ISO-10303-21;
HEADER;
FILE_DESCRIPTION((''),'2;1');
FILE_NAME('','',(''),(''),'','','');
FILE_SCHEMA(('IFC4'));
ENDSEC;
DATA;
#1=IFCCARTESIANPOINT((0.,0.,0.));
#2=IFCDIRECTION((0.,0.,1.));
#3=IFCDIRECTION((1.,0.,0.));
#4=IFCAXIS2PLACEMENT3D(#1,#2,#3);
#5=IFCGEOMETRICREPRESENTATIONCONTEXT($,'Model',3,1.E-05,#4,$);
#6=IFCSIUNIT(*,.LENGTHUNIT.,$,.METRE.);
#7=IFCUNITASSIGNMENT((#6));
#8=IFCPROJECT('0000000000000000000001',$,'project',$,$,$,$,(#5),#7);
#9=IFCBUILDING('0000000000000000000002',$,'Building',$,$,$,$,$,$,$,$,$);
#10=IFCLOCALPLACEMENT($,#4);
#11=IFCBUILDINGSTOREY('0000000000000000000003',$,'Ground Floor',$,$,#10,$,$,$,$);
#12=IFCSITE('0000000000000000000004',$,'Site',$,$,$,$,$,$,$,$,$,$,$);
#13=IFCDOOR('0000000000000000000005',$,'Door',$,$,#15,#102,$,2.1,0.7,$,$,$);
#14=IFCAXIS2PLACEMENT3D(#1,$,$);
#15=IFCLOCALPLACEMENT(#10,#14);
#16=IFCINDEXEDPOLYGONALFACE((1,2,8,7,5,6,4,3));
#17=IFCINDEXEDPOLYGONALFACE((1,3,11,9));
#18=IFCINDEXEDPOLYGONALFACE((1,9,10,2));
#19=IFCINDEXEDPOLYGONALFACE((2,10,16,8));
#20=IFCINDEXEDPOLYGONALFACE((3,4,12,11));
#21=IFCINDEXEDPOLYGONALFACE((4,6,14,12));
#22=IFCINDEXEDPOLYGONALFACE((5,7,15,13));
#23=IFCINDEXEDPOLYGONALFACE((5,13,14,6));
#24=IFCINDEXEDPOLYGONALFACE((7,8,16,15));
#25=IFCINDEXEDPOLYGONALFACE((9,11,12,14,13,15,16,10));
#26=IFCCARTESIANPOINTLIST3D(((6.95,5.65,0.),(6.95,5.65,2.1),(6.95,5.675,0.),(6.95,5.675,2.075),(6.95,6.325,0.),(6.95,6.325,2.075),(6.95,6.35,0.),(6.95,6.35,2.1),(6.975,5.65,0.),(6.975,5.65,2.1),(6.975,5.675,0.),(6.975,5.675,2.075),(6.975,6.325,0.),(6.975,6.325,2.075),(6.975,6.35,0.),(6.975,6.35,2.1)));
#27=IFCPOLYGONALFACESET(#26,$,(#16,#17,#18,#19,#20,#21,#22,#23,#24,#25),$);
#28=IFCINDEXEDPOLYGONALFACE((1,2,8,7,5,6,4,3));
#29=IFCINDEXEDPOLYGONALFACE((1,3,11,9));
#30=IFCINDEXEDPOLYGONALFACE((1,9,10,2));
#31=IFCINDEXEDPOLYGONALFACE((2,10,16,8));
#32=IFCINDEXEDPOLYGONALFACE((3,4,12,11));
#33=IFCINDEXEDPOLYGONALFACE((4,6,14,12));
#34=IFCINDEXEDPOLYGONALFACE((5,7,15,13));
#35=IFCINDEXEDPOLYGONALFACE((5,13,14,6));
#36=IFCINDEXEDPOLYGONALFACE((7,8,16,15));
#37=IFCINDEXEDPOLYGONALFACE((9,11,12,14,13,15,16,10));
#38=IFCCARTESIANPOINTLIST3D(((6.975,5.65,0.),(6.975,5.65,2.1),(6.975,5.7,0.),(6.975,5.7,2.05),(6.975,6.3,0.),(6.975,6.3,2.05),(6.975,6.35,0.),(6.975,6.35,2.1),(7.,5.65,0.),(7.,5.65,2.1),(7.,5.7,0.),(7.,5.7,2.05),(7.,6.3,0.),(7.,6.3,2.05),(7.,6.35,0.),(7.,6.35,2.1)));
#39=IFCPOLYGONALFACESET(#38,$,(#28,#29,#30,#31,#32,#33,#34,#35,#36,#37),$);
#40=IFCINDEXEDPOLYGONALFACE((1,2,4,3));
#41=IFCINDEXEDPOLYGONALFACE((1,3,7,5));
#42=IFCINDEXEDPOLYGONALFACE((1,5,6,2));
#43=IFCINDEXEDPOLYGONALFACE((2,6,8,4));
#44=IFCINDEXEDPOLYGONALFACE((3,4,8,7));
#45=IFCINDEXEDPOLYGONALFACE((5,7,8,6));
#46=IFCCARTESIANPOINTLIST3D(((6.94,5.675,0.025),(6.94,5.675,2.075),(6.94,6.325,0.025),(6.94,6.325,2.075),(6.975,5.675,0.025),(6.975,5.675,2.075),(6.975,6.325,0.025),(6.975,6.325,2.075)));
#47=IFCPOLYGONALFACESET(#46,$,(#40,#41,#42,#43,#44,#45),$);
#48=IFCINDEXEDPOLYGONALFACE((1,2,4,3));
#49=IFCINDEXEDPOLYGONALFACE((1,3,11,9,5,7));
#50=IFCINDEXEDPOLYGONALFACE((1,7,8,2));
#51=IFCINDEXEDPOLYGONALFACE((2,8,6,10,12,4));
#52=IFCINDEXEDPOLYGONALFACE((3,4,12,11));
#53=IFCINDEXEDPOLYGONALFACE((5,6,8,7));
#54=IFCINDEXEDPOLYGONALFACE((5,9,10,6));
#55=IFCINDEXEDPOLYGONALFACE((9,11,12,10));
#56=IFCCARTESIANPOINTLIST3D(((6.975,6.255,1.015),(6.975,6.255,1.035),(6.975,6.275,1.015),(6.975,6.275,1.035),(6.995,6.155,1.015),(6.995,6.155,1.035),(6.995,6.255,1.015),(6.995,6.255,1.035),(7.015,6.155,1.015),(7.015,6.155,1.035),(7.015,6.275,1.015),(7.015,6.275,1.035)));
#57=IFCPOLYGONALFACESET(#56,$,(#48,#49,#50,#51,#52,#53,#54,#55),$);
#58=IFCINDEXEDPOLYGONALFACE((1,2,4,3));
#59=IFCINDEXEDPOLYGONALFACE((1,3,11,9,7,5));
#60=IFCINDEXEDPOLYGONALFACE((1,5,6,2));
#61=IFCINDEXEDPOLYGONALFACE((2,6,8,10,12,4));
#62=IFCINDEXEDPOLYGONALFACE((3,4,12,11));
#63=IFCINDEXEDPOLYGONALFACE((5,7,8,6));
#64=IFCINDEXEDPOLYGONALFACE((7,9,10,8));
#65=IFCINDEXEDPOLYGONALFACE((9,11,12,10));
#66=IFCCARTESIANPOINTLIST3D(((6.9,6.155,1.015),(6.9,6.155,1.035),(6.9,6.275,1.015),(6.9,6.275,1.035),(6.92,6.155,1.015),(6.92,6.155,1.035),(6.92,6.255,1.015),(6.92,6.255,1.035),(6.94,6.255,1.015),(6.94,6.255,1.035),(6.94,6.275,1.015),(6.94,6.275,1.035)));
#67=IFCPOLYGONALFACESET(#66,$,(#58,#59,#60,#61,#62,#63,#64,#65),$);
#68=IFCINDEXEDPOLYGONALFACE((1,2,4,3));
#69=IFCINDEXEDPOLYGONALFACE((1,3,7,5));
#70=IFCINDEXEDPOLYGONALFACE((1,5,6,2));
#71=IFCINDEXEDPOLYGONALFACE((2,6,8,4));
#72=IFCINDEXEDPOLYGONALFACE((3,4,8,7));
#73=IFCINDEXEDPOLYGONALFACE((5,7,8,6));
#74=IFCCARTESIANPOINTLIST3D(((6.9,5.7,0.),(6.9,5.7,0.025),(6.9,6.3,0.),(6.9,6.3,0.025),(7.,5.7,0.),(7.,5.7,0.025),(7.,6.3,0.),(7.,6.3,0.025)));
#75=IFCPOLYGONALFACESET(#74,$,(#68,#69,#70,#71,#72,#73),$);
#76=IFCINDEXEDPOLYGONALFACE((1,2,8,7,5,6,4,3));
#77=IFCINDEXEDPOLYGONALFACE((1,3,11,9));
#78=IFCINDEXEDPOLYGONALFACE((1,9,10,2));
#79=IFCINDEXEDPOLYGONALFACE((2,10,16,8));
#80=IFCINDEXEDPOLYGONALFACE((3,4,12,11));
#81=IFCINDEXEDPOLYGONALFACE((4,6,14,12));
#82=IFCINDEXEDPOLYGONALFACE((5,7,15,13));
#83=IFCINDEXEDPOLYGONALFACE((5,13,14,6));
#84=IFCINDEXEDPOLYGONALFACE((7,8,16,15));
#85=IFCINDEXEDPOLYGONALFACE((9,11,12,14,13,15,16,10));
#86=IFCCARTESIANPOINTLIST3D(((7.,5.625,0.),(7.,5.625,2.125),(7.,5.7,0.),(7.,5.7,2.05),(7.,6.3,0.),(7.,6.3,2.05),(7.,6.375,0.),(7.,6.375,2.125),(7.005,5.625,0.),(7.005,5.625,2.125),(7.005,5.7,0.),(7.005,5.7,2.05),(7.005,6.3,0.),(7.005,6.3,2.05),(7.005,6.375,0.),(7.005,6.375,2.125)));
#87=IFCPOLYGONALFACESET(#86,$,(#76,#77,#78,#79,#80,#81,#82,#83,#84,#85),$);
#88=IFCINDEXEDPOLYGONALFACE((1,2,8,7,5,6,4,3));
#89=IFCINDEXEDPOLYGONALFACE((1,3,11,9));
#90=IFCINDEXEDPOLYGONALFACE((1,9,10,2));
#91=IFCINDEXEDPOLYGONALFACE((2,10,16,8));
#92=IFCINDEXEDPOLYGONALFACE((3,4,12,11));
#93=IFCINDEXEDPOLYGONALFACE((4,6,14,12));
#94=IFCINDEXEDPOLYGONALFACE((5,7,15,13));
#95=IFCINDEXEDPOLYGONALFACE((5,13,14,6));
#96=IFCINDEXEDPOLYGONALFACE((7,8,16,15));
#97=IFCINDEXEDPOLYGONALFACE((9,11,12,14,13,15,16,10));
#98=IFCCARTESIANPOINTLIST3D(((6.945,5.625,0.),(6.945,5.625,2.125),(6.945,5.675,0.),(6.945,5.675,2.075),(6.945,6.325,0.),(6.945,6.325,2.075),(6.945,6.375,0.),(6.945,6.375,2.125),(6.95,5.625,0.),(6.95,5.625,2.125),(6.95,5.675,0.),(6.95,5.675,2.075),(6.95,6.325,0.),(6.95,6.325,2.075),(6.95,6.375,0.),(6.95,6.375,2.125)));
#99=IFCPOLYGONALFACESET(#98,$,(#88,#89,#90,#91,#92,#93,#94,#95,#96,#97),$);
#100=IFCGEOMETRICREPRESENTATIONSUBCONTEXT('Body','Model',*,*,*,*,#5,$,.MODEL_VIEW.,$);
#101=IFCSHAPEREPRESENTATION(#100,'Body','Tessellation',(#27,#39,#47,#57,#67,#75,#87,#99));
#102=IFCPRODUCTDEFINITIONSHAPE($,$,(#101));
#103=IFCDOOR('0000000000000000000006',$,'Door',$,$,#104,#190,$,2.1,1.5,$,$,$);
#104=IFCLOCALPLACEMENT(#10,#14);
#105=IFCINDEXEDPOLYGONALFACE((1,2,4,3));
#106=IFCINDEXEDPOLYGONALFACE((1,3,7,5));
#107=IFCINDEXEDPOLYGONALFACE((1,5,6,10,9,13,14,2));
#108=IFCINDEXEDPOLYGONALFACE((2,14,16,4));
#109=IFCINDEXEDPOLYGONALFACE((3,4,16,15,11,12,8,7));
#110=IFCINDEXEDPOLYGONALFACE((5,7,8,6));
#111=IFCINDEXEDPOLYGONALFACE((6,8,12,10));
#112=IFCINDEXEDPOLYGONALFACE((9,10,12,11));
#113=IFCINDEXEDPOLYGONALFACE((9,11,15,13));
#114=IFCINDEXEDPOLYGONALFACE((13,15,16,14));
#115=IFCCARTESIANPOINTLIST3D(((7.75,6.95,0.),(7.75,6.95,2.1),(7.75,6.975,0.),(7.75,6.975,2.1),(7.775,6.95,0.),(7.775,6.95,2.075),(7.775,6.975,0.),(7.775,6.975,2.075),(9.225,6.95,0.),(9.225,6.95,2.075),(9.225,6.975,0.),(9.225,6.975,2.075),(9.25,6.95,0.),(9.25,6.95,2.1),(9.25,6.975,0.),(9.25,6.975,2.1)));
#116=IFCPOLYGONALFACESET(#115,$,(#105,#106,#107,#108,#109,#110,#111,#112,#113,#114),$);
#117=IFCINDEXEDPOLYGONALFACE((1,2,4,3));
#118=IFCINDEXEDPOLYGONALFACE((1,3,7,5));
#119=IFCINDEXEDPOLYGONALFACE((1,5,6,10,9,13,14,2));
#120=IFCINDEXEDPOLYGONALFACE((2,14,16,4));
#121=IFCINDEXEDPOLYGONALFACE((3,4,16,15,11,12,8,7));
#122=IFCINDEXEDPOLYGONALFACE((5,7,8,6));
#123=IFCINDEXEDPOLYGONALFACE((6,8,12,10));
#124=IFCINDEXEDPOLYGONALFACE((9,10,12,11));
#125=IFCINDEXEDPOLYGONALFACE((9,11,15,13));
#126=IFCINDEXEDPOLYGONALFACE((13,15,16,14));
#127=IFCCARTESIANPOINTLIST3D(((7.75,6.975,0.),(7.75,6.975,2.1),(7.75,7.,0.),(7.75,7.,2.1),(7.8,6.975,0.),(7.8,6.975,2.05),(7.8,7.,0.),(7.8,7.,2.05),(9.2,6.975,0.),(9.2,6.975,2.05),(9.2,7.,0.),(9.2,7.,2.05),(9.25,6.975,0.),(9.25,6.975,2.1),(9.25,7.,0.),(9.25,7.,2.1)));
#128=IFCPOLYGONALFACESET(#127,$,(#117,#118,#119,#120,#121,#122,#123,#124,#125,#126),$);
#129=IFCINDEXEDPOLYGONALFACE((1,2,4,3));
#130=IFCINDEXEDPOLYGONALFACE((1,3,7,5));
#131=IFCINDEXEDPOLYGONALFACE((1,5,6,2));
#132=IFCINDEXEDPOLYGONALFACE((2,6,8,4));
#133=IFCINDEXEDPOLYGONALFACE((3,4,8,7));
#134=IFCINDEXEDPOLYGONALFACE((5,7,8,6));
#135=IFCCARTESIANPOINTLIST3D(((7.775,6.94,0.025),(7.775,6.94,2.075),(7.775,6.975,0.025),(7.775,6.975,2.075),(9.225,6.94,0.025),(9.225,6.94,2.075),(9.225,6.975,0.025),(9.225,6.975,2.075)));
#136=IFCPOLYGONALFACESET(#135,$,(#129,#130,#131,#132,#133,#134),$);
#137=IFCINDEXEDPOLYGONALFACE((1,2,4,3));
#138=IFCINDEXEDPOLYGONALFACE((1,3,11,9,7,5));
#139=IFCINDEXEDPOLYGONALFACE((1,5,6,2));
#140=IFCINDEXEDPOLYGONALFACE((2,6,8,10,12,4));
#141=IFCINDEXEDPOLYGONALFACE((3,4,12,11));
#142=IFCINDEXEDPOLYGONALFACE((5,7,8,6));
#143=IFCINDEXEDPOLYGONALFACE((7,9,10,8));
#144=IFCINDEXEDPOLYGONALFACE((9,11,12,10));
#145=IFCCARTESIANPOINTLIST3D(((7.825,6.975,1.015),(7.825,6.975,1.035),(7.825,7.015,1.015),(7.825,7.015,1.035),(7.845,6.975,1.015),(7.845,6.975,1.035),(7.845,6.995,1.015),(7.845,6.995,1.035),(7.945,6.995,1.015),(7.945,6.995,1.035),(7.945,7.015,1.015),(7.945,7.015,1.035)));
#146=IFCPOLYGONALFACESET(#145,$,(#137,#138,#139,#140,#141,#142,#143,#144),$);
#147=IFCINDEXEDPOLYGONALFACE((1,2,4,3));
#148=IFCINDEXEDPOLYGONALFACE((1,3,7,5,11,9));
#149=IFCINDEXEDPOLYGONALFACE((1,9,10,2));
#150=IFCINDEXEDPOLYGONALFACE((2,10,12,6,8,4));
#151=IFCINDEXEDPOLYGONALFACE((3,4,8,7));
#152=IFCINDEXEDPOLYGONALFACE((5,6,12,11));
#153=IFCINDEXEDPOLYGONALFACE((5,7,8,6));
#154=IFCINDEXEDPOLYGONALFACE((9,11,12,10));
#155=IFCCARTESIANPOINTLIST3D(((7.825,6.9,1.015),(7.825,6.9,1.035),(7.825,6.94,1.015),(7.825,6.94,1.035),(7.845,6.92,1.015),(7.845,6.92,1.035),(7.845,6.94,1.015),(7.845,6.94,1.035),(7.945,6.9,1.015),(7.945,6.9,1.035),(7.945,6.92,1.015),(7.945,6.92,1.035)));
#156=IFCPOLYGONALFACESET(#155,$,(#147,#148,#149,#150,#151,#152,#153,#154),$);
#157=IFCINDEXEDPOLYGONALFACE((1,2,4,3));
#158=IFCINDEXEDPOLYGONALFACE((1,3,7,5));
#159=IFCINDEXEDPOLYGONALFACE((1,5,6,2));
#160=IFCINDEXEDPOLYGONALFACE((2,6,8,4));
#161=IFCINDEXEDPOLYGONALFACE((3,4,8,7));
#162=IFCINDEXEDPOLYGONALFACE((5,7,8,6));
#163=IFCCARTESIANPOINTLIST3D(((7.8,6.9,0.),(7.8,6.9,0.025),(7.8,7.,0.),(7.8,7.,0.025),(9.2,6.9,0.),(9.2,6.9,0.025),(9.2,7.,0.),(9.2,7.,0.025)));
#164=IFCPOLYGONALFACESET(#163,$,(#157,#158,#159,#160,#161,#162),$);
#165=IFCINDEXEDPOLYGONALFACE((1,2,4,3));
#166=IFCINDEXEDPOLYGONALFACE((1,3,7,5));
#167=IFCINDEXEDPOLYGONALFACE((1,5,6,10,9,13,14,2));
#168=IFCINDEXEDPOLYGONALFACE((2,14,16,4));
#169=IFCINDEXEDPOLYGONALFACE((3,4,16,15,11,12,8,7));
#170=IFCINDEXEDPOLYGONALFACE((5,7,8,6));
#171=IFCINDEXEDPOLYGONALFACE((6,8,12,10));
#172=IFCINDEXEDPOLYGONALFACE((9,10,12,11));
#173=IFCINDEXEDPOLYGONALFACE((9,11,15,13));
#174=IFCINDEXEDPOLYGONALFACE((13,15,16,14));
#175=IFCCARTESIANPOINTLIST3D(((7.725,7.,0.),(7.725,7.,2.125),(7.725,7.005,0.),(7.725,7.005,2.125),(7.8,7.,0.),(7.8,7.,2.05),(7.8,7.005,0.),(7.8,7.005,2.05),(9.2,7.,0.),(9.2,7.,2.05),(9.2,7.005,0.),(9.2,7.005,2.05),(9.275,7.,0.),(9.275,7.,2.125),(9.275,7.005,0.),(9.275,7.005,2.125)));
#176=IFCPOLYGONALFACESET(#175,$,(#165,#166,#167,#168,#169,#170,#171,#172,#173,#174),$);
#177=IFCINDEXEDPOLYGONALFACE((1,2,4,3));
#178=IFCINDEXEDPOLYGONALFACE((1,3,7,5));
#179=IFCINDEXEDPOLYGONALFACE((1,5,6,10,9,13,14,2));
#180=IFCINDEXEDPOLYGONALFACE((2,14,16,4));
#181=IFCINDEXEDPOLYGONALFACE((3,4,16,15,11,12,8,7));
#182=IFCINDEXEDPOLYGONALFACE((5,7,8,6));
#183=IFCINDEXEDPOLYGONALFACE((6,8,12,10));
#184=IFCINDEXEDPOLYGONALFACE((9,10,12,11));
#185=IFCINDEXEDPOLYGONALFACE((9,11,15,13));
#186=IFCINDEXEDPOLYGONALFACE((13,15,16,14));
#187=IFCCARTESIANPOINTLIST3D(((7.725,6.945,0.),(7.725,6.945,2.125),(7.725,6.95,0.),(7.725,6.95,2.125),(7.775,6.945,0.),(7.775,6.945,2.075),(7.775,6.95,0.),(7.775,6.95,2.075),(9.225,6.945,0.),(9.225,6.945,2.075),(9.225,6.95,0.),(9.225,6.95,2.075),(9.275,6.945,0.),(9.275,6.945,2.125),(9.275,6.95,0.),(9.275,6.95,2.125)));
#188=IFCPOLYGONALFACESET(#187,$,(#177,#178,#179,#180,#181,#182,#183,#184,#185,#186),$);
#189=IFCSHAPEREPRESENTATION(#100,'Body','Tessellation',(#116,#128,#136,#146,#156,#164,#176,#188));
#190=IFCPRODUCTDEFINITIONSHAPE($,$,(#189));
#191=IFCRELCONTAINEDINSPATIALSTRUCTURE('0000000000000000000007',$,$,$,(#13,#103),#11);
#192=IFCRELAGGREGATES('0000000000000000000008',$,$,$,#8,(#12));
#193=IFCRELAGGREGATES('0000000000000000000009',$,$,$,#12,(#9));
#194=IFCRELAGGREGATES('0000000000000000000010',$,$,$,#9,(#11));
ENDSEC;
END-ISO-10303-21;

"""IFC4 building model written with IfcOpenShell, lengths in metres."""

from ifc_helpers import new_model, si_unit, frame, origin_with_axes, place, context, subcontext, project, spatial, line, indexed_curve, outline, extrude, element, save


model = new_model("IFC4")

# Units and contexts
model_context = context("Model", 3, precision=1e-05, world=origin_with_axes())
body_context = subcontext(model_context, "Body", "Model", "MODEL_VIEW")
ifc_project = project(units=[si_unit("LENGTHUNIT", "METRE")], contexts=[model_context])

# Site, building, storey
site = spatial("IfcSite", under=ifc_project, Name="Site")
building = spatial("IfcBuilding", under=site, Name="Building")
storey_placement = place(None, origin_with_axes())
storey = spatial("IfcBuildingStorey", under=building, at=storey_placement, Name="Ground Floor")

# Doors
door_1_placement = place(storey_placement, frame((7.0, 5.65, 0.0), z_axis=(0.0, 0.0, 1.0), x_axis=(0.0, 1.0, 0.0)))
element("IfcDoor", 1, at=door_1_placement, inside=storey, Name="Door", OverallHeight=2.1, OverallWidth=0.7, context=body_context, shape_type="SweptSolid", body=[
    extrude(outline(indexed_curve([(0.0, 0.0), (0.0, 2.1), (0.7, 2.1), (0.7, 0.0), (0.675, 0.0), (0.675, 2.075), (0.025, 2.075), (0.025, 0.0)], segments=[line(1, 2, 3, 4, 5, 6, 7, 8, 1)])), frame((0.0, 0.025, 0.0), z_axis=(0.0, -1.0, 0.0), x_axis=(1.0, 0.0, 0.0)), (0.0, 0.0, -1.0), 0.025),
    extrude(outline(indexed_curve([(0.0, 0.0), (0.0, 2.1), (0.7, 2.1), (0.7, 0.0), (0.65, 0.0), (0.65, 2.05), (0.05, 2.05), (0.05, 0.0)], segments=[line(1, 2, 3, 4, 5, 6, 7, 8, 1)])), frame((0.0, 0.0, 0.0), z_axis=(0.0, -1.0, 0.0), x_axis=(1.0, 0.0, 0.0)), (0.0, 0.0, -1.0), 0.025),
    extrude(outline(indexed_curve([(0.0, 0.0), (0.65, 0.0), (0.65, 0.035), (0.0, 0.035)], segments=[line(1, 2, 3, 4, 1)])), frame((0.025, 0.025, 0.025), z_axis=(0.0, 0.0, 1.0), x_axis=(1.0, 0.0, 0.0)), (0.0, 0.0, 1.0), 2.05),
    extrude(outline(indexed_curve([(0.0, 0.0), (0.0, -0.04), (-0.12, -0.04), (-0.12, -0.02), (-0.02, -0.02), (-0.02, 0.0)], segments=[line(1, 2, 3, 4, 5, 6, 1)])), frame((0.625, 0.025, 1.015), z_axis=(0.0, 0.0, 1.0), x_axis=(1.0, 0.0, 0.0)), (0.0, 0.0, 1.0), 0.02),
    extrude(outline(indexed_curve([(0.0, 0.0), (0.0, 0.04), (-0.12, 0.04), (-0.12, 0.02), (-0.02, 0.02), (-0.02, 0.0)], segments=[line(1, 2, 3, 4, 5, 6, 1)])), frame((0.625, 0.06, 1.015), z_axis=(0.0, 0.0, 1.0), x_axis=(1.0, 0.0, 0.0)), (0.0, 0.0, 1.0), 0.02),
    extrude(outline(indexed_curve([(0.0, 0.0), (0.6, 0.0), (0.6, 0.1), (0.0, 0.1)], segments=[line(1, 2, 3, 4, 1)])), frame((0.05, 0.0, 0.0), z_axis=(0.0, 0.0, 1.0), x_axis=(1.0, 0.0, 0.0)), (0.0, 0.0, 1.0), 0.025),
    extrude(outline(indexed_curve([(0.0, 0.0), (0.0, 2.125), (0.75, 2.125), (0.75, 0.0), (0.675, 0.0), (0.675, 2.05), (0.075, 2.05), (0.075, 0.0)], segments=[line(1, 2, 3, 4, 5, 6, 7, 8, 1)])), frame((-0.025, -0.005, 0.0), z_axis=(0.0, -1.0, 0.0), x_axis=(1.0, 0.0, 0.0)), (0.0, 0.0, -1.0), 0.005),
    extrude(outline(indexed_curve([(0.0, 0.0), (0.0, 2.125), (0.75, 2.125), (0.75, 0.0), (0.7, 0.0), (0.7, 2.075), (0.05, 2.075), (0.05, 0.0)], segments=[line(1, 2, 3, 4, 5, 6, 7, 8, 1)])), frame((-0.025, 0.05, 0.0), z_axis=(0.0, -1.0, 0.0), x_axis=(1.0, 0.0, 0.0)), (0.0, 0.0, -1.0), 0.005),
])
door_2_placement = place(storey_placement, frame((9.25, 7.0, 0.0), z_axis=(0.0, 0.0, 1.0), x_axis=(-1.0, 0.0, 0.0)))
element("IfcDoor", 2, at=door_2_placement, inside=storey, Name="Door", OverallHeight=2.1, OverallWidth=1.5, context=body_context, shape_type="SweptSolid", body=[
    extrude(outline(indexed_curve([(0.0, 0.0), (0.0, 2.1), (1.5, 2.1), (1.5, 0.0), (1.475, 0.0), (1.475, 2.075), (0.025, 2.075), (0.025, 0.0)], segments=[line(1, 2, 3, 4, 5, 6, 7, 8, 1)])), frame((0.0, 0.025, 0.0), z_axis=(0.0, -1.0, 0.0), x_axis=(1.0, 0.0, 0.0)), (0.0, 0.0, -1.0), 0.025),
    extrude(outline(indexed_curve([(0.0, 0.0), (0.0, 2.1), (1.5, 2.1), (1.5, 0.0), (1.45, 0.0), (1.45, 2.05), (0.05, 2.05), (0.05, 0.0)], segments=[line(1, 2, 3, 4, 5, 6, 7, 8, 1)])), frame((0.0, 0.0, 0.0), z_axis=(0.0, -1.0, 0.0), x_axis=(1.0, 0.0, 0.0)), (0.0, 0.0, -1.0), 0.025),
    extrude(outline(indexed_curve([(0.0, 0.0), (1.45, 0.0), (1.45, 0.035), (0.0, 0.035)], segments=[line(1, 2, 3, 4, 1)])), frame((0.025, 0.025, 0.025), z_axis=(0.0, 0.0, 1.0), x_axis=(1.0, 0.0, 0.0)), (0.0, 0.0, 1.0), 2.05),
    extrude(outline(indexed_curve([(0.0, 0.0), (0.0, -0.04), (-0.12, -0.04), (-0.12, -0.02), (-0.02, -0.02), (-0.02, 0.0)], segments=[line(1, 2, 3, 4, 5, 6, 1)])), frame((1.425, 0.025, 1.015), z_axis=(0.0, 0.0, 1.0), x_axis=(1.0, 0.0, 0.0)), (0.0, 0.0, 1.0), 0.02),
    extrude(outline(indexed_curve([(0.0, 0.0), (0.0, 0.04), (-0.12, 0.04), (-0.12, 0.02), (-0.02, 0.02), (-0.02, 0.0)], segments=[line(1, 2, 3, 4, 5, 6, 1)])), frame((1.425, 0.06, 1.015), z_axis=(0.0, 0.0, 1.0), x_axis=(1.0, 0.0, 0.0)), (0.0, 0.0, 1.0), 0.02),
    extrude(outline(indexed_curve([(0.0, 0.0), (1.4, 0.0), (1.4, 0.1), (0.0, 0.1)], segments=[line(1, 2, 3, 4, 1)])), frame((0.05, 0.0, 0.0), z_axis=(0.0, 0.0, 1.0), x_axis=(1.0, 0.0, 0.0)), (0.0, 0.0, 1.0), 0.025),
    extrude(outline(indexed_curve([(0.0, 0.0), (0.0, 2.125), (1.55, 2.125), (1.55, 0.0), (1.475, 0.0), (1.475, 2.05), (0.075, 2.05), (0.075, 0.0)], segments=[line(1, 2, 3, 4, 5, 6, 7, 8, 1)])), frame((-0.025, -0.005, 0.0), z_axis=(0.0, -1.0, 0.0), x_axis=(1.0, 0.0, 0.0)), (0.0, 0.0, -1.0), 0.005),
    extrude(outline(indexed_curve([(0.0, 0.0), (0.0, 2.125), (1.55, 2.125), (1.55, 0.0), (1.5, 0.0), (1.5, 2.075), (0.05, 2.075), (0.05, 0.0)], segments=[line(1, 2, 3, 4, 5, 6, 7, 8, 1)])), frame((-0.025, 0.05, 0.0), z_axis=(0.0, -1.0, 0.0), x_axis=(1.0, 0.0, 0.0)), (0.0, 0.0, -1.0), 0.005),
])

save(model, "model.ifc")
